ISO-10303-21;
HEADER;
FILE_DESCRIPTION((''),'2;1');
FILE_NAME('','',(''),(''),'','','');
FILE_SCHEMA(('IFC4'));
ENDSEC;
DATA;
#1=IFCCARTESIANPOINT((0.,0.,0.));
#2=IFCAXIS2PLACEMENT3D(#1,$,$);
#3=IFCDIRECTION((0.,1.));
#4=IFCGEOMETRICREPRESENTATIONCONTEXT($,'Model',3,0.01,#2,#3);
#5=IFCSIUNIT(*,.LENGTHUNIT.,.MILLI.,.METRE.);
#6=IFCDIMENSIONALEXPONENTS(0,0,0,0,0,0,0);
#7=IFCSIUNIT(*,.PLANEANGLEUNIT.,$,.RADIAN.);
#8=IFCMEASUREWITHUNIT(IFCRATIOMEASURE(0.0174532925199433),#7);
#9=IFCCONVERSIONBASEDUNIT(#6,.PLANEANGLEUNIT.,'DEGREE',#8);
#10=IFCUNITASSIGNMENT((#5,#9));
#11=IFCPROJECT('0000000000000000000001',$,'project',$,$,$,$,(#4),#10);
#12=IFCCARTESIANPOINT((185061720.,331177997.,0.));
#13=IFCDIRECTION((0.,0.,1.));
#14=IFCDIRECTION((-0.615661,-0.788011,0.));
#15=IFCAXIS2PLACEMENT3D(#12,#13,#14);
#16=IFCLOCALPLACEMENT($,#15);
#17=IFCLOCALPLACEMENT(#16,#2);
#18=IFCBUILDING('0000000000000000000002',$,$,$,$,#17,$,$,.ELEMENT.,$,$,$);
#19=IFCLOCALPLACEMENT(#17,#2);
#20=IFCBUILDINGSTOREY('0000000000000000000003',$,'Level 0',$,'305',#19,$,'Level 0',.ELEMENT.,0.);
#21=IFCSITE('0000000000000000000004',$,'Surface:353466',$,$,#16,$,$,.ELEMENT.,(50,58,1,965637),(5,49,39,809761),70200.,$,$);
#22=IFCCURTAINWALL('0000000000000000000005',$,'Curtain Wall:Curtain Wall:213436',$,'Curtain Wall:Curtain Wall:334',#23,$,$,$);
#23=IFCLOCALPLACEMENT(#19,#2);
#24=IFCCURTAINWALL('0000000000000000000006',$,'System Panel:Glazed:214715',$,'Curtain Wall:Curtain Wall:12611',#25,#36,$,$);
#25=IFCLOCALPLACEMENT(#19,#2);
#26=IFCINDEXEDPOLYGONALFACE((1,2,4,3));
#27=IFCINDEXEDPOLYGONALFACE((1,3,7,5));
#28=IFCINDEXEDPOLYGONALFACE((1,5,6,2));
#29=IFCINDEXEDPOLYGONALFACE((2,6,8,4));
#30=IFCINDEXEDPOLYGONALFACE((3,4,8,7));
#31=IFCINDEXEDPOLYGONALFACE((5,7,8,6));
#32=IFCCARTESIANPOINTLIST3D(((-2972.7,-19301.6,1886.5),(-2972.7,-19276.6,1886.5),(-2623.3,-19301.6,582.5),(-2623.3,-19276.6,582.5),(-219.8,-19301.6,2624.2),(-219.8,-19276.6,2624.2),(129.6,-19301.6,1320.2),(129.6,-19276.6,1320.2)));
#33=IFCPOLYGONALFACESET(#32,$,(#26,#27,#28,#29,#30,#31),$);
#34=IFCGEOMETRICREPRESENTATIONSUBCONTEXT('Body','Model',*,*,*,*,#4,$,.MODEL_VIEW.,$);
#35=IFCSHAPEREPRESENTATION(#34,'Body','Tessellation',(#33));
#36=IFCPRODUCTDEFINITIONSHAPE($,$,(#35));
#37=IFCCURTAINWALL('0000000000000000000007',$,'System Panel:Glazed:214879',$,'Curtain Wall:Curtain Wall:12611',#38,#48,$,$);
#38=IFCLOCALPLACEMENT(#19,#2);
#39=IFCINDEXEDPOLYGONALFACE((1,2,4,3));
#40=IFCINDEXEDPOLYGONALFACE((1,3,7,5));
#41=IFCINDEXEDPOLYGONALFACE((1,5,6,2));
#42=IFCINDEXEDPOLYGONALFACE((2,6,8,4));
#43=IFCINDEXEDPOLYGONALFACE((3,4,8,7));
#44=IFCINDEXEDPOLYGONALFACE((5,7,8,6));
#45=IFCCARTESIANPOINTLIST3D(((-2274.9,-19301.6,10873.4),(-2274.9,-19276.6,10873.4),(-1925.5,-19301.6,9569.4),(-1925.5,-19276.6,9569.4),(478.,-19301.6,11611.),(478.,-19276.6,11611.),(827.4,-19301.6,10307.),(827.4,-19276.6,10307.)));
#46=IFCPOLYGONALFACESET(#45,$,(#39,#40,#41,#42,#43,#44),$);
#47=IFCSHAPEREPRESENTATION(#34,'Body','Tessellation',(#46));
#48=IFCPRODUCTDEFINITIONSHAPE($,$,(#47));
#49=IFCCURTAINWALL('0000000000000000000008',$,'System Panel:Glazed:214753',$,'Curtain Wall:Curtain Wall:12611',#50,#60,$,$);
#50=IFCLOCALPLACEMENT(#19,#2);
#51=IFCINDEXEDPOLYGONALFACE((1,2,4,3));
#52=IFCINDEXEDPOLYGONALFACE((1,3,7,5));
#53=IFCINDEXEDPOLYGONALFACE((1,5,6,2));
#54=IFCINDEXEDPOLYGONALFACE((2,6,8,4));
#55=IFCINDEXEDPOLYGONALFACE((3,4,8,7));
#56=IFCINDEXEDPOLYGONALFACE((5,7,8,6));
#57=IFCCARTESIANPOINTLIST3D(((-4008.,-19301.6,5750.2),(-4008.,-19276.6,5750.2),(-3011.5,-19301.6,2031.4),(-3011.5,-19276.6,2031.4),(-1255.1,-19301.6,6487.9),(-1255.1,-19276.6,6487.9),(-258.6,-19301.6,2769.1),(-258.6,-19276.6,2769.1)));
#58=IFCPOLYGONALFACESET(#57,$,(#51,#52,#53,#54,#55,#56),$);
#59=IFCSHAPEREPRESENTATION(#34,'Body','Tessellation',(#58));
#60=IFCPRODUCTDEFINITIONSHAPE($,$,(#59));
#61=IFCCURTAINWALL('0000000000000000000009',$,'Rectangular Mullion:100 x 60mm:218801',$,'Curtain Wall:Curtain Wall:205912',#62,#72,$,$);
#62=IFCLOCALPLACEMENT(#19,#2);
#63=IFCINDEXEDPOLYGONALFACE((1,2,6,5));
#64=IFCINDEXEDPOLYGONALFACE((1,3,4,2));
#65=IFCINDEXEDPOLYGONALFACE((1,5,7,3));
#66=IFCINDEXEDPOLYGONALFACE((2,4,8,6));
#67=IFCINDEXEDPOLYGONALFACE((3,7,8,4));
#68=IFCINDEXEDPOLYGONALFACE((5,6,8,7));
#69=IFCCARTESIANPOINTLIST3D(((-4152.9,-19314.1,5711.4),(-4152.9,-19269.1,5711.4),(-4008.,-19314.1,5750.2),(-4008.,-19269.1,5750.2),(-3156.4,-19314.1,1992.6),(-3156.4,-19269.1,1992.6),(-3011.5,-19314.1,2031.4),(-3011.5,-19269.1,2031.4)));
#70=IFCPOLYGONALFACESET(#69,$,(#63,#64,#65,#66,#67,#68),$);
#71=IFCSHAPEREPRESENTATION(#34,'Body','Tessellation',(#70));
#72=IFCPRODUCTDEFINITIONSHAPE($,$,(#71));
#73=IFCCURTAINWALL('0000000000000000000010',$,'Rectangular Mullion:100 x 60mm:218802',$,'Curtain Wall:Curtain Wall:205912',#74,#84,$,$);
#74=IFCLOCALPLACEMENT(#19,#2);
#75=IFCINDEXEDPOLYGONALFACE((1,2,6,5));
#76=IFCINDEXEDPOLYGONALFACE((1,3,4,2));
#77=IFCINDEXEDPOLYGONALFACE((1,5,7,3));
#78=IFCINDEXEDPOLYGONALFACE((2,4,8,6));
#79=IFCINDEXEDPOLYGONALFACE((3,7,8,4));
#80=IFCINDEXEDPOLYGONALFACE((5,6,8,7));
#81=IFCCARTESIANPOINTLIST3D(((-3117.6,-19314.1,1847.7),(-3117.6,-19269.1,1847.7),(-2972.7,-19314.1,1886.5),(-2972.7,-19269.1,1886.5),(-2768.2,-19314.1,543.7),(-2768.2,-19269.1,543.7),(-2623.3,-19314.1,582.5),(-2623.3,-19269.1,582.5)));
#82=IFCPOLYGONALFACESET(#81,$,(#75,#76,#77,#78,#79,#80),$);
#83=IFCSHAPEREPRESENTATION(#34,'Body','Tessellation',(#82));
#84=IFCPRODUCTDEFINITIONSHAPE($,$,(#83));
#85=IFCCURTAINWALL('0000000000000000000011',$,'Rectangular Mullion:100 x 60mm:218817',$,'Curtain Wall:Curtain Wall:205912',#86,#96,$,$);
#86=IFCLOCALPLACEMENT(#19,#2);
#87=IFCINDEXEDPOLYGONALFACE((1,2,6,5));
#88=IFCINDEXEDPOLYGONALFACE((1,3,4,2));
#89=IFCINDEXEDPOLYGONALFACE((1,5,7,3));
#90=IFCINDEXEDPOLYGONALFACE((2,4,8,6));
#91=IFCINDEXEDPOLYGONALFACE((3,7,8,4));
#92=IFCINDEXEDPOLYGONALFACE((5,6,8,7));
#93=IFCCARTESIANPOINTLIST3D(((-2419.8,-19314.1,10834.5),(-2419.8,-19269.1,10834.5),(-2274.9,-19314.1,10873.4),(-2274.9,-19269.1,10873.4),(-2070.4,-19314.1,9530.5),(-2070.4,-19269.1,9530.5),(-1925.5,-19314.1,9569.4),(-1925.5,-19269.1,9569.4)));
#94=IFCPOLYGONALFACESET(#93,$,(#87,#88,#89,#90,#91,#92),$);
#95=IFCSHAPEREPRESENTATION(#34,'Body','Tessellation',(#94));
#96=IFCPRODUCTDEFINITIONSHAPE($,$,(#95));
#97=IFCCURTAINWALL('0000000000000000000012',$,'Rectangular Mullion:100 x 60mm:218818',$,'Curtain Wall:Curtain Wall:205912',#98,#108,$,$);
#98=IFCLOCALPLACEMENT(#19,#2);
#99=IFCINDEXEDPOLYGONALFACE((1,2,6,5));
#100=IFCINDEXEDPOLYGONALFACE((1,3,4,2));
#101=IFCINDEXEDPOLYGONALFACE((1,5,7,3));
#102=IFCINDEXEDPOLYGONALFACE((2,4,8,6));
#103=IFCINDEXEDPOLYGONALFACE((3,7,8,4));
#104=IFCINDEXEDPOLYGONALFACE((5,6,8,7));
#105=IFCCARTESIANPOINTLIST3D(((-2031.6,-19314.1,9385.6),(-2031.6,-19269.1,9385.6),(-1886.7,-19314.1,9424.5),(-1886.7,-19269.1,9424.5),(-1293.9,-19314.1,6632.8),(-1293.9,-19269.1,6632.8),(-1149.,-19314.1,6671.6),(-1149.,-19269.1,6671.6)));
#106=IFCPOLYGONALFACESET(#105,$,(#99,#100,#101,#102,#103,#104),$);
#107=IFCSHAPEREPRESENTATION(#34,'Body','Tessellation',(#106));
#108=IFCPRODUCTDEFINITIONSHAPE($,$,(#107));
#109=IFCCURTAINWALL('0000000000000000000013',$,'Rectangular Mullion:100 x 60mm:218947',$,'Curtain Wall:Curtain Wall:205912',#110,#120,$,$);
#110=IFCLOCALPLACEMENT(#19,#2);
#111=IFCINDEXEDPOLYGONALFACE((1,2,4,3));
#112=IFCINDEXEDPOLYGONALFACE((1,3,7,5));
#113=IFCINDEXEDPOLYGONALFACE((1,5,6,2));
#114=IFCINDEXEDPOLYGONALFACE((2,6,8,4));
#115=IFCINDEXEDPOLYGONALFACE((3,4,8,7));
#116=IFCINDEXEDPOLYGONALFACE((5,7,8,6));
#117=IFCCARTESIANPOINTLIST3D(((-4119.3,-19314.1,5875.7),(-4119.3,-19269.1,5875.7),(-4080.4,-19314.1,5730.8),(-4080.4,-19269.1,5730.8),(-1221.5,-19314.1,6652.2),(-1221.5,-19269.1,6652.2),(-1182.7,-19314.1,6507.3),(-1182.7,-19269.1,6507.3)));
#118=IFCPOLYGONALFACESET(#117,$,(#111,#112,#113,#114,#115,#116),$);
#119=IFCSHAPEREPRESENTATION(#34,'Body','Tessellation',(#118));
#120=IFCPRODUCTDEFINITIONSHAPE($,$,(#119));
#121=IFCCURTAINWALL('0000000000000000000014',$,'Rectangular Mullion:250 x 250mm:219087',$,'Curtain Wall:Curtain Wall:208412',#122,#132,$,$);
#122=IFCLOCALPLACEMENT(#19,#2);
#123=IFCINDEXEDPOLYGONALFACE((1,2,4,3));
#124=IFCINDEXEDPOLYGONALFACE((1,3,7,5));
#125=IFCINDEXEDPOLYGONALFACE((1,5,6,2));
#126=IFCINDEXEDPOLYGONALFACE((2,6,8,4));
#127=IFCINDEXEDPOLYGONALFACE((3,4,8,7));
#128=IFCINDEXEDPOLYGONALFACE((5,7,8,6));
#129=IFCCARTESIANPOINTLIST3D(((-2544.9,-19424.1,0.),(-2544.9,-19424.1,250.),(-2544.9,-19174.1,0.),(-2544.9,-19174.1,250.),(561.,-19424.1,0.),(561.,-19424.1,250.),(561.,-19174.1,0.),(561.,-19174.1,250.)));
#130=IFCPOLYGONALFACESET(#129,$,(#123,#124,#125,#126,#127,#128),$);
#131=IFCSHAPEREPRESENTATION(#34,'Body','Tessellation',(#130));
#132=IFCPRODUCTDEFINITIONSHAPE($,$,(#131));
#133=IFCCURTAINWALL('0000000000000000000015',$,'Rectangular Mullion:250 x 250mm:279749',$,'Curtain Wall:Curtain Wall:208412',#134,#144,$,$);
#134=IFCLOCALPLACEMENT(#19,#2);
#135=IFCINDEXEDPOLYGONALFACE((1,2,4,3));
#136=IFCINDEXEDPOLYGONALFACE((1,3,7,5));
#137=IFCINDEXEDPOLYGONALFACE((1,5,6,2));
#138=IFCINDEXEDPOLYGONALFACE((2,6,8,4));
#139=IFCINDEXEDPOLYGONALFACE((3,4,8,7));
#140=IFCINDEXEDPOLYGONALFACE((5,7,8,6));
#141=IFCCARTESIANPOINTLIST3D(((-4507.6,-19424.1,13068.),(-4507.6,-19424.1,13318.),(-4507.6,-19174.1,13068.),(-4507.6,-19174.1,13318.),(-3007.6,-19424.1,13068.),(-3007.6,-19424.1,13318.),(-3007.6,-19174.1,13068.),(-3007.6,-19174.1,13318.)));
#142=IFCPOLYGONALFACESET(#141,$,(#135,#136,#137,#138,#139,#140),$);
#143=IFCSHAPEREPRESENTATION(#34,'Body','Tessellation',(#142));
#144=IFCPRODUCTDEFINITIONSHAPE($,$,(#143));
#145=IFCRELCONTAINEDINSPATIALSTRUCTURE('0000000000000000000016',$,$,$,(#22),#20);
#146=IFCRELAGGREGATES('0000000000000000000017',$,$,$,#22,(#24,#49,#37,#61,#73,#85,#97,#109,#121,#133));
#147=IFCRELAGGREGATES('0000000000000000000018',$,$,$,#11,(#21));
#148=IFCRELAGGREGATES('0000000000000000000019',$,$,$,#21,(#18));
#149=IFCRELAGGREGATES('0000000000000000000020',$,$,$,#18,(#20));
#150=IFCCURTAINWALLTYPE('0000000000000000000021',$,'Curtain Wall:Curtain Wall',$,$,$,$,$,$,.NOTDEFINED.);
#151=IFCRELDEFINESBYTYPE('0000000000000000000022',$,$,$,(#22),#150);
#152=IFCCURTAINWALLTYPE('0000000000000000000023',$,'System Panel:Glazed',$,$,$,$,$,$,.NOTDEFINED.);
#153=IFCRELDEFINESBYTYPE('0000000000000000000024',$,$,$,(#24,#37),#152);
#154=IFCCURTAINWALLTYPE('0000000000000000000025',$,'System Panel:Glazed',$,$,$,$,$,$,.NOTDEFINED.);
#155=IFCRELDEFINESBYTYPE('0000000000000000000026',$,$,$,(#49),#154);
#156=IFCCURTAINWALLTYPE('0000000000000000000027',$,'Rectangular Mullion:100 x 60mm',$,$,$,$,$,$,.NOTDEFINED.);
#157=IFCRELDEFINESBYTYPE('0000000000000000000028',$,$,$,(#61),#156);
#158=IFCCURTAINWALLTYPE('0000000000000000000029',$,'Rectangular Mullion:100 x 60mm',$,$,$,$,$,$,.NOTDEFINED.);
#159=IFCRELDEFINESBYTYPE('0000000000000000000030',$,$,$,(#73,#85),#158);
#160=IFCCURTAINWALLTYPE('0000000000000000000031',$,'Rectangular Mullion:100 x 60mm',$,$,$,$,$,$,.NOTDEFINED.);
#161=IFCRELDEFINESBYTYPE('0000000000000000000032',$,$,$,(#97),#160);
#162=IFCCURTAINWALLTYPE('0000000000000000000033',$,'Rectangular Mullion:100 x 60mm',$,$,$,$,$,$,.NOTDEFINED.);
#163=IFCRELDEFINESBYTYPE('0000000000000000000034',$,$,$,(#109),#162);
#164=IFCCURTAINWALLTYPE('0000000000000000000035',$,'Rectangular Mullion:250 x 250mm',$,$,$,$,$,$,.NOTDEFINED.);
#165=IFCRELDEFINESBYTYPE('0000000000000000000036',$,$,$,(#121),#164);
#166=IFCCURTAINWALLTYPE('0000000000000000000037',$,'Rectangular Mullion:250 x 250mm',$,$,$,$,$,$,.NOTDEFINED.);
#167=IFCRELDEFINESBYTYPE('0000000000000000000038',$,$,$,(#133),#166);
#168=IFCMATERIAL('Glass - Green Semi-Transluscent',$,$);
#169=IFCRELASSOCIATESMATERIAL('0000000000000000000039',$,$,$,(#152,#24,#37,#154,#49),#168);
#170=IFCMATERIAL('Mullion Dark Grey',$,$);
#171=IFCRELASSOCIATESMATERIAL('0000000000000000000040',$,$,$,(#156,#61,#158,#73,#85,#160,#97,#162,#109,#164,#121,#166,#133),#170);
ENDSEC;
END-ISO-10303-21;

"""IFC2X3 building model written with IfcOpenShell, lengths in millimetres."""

from ifc_helpers import new_model, entity, si_unit, converted_unit, direction, frame, frame_2d, origin, origin_2d_with_axis, place, context, subcontext, project, spatial, rectangle, extrude, source, transform, mapped, material, type_object, type_shapes, element, aggregate, save


model = new_model("IFC2X3")

# Units and contexts
model_context = context("Model", 3, precision=0.01, world=origin(), true_north=direction((0.0, 1.0)))
body_context = subcontext(model_context, "Body", "Model", "MODEL_VIEW")
ifc_project = project(units=[si_unit("LENGTHUNIT", "METRE", prefix="MILLI"), converted_unit("PLANEANGLEUNIT", "DEGREE", entity("IfcRatioMeasure", 0.0174532925199433), si_unit("PLANEANGLEUNIT", "RADIAN"), dimensions=[0, 0, 0, 0, 0, 0, 0])], contexts=[model_context])

# Site, building, storey
site_placement = place(None, frame((185061720.0, 331177997.0, 0.0), z_axis=(0.0, 0.0, 1.0), x_axis=(-0.615661, -0.788011, 0.0)))
site = spatial("IfcSite", under=ifc_project, at=site_placement, Name="Surface:353466", CompositionType="ELEMENT", RefLatitude=(50, 58, 1, 965637), RefLongitude=(5, 49, 39, 809761), RefElevation=70200.0)
building_placement = place(site_placement, origin())
building = spatial("IfcBuilding", under=site, at=building_placement, CompositionType="ELEMENT")
storey_placement = place(building_placement, origin())
storey = spatial("IfcBuildingStorey", under=building, at=storey_placement, Name="Level 0", ObjectType="305", LongName="Level 0", CompositionType="ELEMENT", Elevation=0.0)

# Curtain walls
curtain_wall_type_1 = type_object("IfcCurtainWallType", Name="Curtain Wall:Curtain Wall", PredefinedType="NOTDEFINED")
curtain_wall_1_placement = place(storey_placement, origin())
curtain_wall_1 = element("IfcCurtainWall", 1, at=curtain_wall_1_placement, inside=storey, type_object=curtain_wall_type_1, Name="Curtain Wall:Curtain Wall:213436", ObjectType="Curtain Wall:Curtain Wall:334")
ifc_material_1 = material(Name="Glass - Green Semi-Transluscent")
curtain_wall_type_2 = type_object("IfcCurtainWallType", Name="System Panel:Glazed", PredefinedType="NOTDEFINED", material=ifc_material_1)
shared_shape_1 = source(origin(), body_context, "Body", "SweptSolid", [
    extrude(rectangle(XDim=25.0, YDim=2850.0, at=origin_2d_with_axis()), frame((0.0, 10.0, 0.0), z_axis=(0.0, 0.0, 1.0), x_axis=(0.0, 1.0, 0.0)), (0.0, 0.0, 1.0), 1350.0),
])
type_shapes(curtain_wall_type_2, [shared_shape_1])
curtain_wall_2_placement = place(storey_placement, frame((-1246.9, -19299.1, 951.4), z_axis=(-0.258819, 0.0, 0.965926), x_axis=(0.965926, 0.0, 0.258819)))
curtain_wall_2 = element("IfcCurtainWall", 2, at=curtain_wall_2_placement, type_object=curtain_wall_type_2, material=ifc_material_1, Name="System Panel:Glazed:214715", ObjectType="Curtain Wall:Curtain Wall:12611", context=body_context, shape_type="MappedRepresentation", body=[
    mapped(shared_shape_1, transform((0.0, 0.0, 0.0), scale=1.0)),
])
curtain_wall_3_placement = place(storey_placement, frame((-549.0, -19299.1, 9938.2), z_axis=(-0.258819, 0.0, 0.965926), x_axis=(0.965926, 0.0, 0.258819)))
curtain_wall_3 = element("IfcCurtainWall", 3, at=curtain_wall_3_placement, type_object=curtain_wall_type_2, material=ifc_material_1, Name="System Panel:Glazed:214879", ObjectType="Curtain Wall:Curtain Wall:12611", context=body_context, shape_type="MappedRepresentation", body=[
    mapped(shared_shape_1, transform((0.0, 0.0, 0.0), scale=1.0)),
])
curtain_wall_type_3 = type_object("IfcCurtainWallType", Name="System Panel:Glazed", PredefinedType="NOTDEFINED", material=ifc_material_1)
shared_shape_2 = source(origin(), body_context, "Body", "SweptSolid", [
    extrude(rectangle(XDim=25.0, YDim=2850.0, at=origin_2d_with_axis()), frame((0.0, 10.0, 0.0), z_axis=(0.0, 0.0, 1.0), x_axis=(0.0, 1.0, 0.0)), (0.0, 0.0, 1.0), 3850.0),
])
type_shapes(curtain_wall_type_3, [shared_shape_2])
curtain_wall_4_placement = place(storey_placement, frame((-1635.1, -19299.1, 2400.2), z_axis=(-0.258819, 0.0, 0.965926), x_axis=(0.965926, 0.0, 0.258819)))
curtain_wall_4 = element("IfcCurtainWall", 4, at=curtain_wall_4_placement, type_object=curtain_wall_type_3, material=ifc_material_1, Name="System Panel:Glazed:214753", ObjectType="Curtain Wall:Curtain Wall:12611", context=body_context, shape_type="MappedRepresentation", body=[
    mapped(shared_shape_2, transform((0.0, 0.0, 0.0), scale=1.0)),
])
ifc_material_2 = material(Name="Mullion Dark Grey")
curtain_wall_type_4 = type_object("IfcCurtainWallType", Name="Rectangular Mullion:100 x 60mm", PredefinedType="NOTDEFINED", material=ifc_material_2)
shared_shape_3 = source(origin(), body_context, "Body", "SweptSolid", [
    extrude(rectangle(XDim=150.0, YDim=45.0, at=frame_2d((0.0, 0.0), x_axis=(1.0, 0.0))), frame((0.0, -7.5, -3850.0)), (0.0, 0.0, 1.0), 3850.0),
])
type_shapes(curtain_wall_type_4, [shared_shape_3])
curtain_wall_5_placement = place(storey_placement, frame((-3084.0, -19299.1, 2012.0), z_axis=(0.258819, 0.0, -0.965926), x_axis=(0.965926, 0.0, 0.258819)))
curtain_wall_5 = element("IfcCurtainWall", 5, at=curtain_wall_5_placement, type_object=curtain_wall_type_4, material=ifc_material_2, Name="Rectangular Mullion:100 x 60mm:218801", ObjectType="Curtain Wall:Curtain Wall:205912", context=body_context, shape_type="MappedRepresentation", body=[
    mapped(shared_shape_3, transform((0.0, 0.0, 0.0), scale=1.0)),
])
curtain_wall_type_5 = type_object("IfcCurtainWallType", Name="Rectangular Mullion:100 x 60mm", PredefinedType="NOTDEFINED", material=ifc_material_2)
shared_shape_4 = source(origin(), body_context, "Body", "SweptSolid", [
    extrude(rectangle(XDim=150.0, YDim=45.0, at=frame_2d((0.0, 0.0), x_axis=(1.0, 0.0))), frame((0.0, -7.5, -1350.0)), (0.0, 0.0, 1.0), 1350.0),
])
type_shapes(curtain_wall_type_5, [shared_shape_4])
curtain_wall_6_placement = place(storey_placement, frame((-2695.8, -19299.1, 563.1), z_axis=(0.258819, 0.0, -0.965926), x_axis=(0.965926, 0.0, 0.258819)))
curtain_wall_6 = element("IfcCurtainWall", 6, at=curtain_wall_6_placement, type_object=curtain_wall_type_5, material=ifc_material_2, Name="Rectangular Mullion:100 x 60mm:218802", ObjectType="Curtain Wall:Curtain Wall:205912", context=body_context, shape_type="MappedRepresentation", body=[
    mapped(shared_shape_4, transform((0.0, 0.0, 0.0), scale=1.0)),
])
curtain_wall_7_placement = place(storey_placement, frame((-1997.9, -19299.1, 9549.9), z_axis=(0.258819, 0.0, -0.965926), x_axis=(0.965926, 0.0, 0.258819)))
curtain_wall_7 = element("IfcCurtainWall", 7, at=curtain_wall_7_placement, type_object=curtain_wall_type_5, material=ifc_material_2, Name="Rectangular Mullion:100 x 60mm:218817", ObjectType="Curtain Wall:Curtain Wall:205912", context=body_context, shape_type="MappedRepresentation", body=[
    mapped(shared_shape_4, transform((0.0, 0.0, 0.0), scale=1.0)),
])
curtain_wall_type_6 = type_object("IfcCurtainWallType", Name="Rectangular Mullion:100 x 60mm", PredefinedType="NOTDEFINED", material=ifc_material_2)
shared_shape_5 = source(origin(), body_context, "Body", "SweptSolid", [
    extrude(rectangle(XDim=150.0, YDim=45.0, at=frame_2d((0.0, 0.0), x_axis=(1.0, 0.0))), frame((0.0, -7.5, -2850.0)), (0.0, 0.0, 1.0), 2850.0),
])
type_shapes(curtain_wall_type_6, [shared_shape_5])
curtain_wall_8_placement = place(storey_placement, frame((-1221.5, -19299.1, 6652.2), z_axis=(0.258819, 0.0, -0.965926), x_axis=(0.965926, 0.0, 0.258819)))
curtain_wall_8 = element("IfcCurtainWall", 8, at=curtain_wall_8_placement, type_object=curtain_wall_type_6, material=ifc_material_2, Name="Rectangular Mullion:100 x 60mm:218818", ObjectType="Curtain Wall:Curtain Wall:205912", context=body_context, shape_type="MappedRepresentation", body=[
    mapped(shared_shape_5, transform((0.0, 0.0, 0.0), scale=1.0)),
])
curtain_wall_type_7 = type_object("IfcCurtainWallType", Name="Rectangular Mullion:100 x 60mm", PredefinedType="NOTDEFINED", material=ifc_material_2)
shared_shape_6 = source(origin(), body_context, "Body", "SweptSolid", [
    extrude(rectangle(XDim=150.0, YDim=45.0, at=frame_2d((0.0, 0.0), x_axis=(1.0, 0.0))), frame((0.0, -7.5, -3000.0)), (0.0, 0.0, 1.0), 3000.0),
])
type_shapes(curtain_wall_type_7, [shared_shape_6])
curtain_wall_9_placement = place(storey_placement, frame((-1202.1, -19299.1, 6579.7), z_axis=(0.965926, 0.0, 0.258819), x_axis=(-0.258819, 0.0, 0.965926)))
curtain_wall_9 = element("IfcCurtainWall", 9, at=curtain_wall_9_placement, type_object=curtain_wall_type_7, material=ifc_material_2, Name="Rectangular Mullion:100 x 60mm:218947", ObjectType="Curtain Wall:Curtain Wall:205912", context=body_context, shape_type="MappedRepresentation", body=[
    mapped(shared_shape_6, transform((0.0, 0.0, 0.0), scale=1.0)),
])
curtain_wall_type_8 = type_object("IfcCurtainWallType", Name="Rectangular Mullion:250 x 250mm", PredefinedType="NOTDEFINED", material=ifc_material_2)
shared_shape_7 = source(origin(), body_context, "Body", "SweptSolid", [
    extrude(rectangle(XDim=250.0, YDim=250.0, at=origin_2d_with_axis()), frame((-125.0, 0.0, -3105.8), z_axis=(0.0, 0.0, 1.0), x_axis=(-1.0, 0.0, 0.0)), (0.0, 0.0, 1.0), 3105.8),
])
type_shapes(curtain_wall_type_8, [shared_shape_7])
curtain_wall_10_placement = place(storey_placement, frame((-2544.9, -19299.1, 0.0), z_axis=(-1.0, 0.0, 0.0), x_axis=(0.0, 0.0, -1.0)))
curtain_wall_10 = element("IfcCurtainWall", 10, at=curtain_wall_10_placement, type_object=curtain_wall_type_8, material=ifc_material_2, Name="Rectangular Mullion:250 x 250mm:219087", ObjectType="Curtain Wall:Curtain Wall:208412", context=body_context, shape_type="MappedRepresentation", body=[
    mapped(shared_shape_7, transform((0.0, 0.0, 0.0), scale=1.0)),
])
curtain_wall_type_9 = type_object("IfcCurtainWallType", Name="Rectangular Mullion:250 x 250mm", PredefinedType="NOTDEFINED", material=ifc_material_2)
shared_shape_8 = source(origin(), body_context, "Body", "SweptSolid", [
    extrude(rectangle(XDim=250.0, YDim=250.0, at=origin_2d_with_axis()), frame((-125.0, 0.0, -1500.0), z_axis=(0.0, 0.0, 1.0), x_axis=(-1.0, 0.0, 0.0)), (0.0, 0.0, 1.0), 1500.0),
])
type_shapes(curtain_wall_type_9, [shared_shape_8])
curtain_wall_11_placement = place(storey_placement, frame((-3007.6, -19299.1, 13318.0), z_axis=(1.0, 0.0, 0.0), x_axis=(0.0, 0.0, 1.0)))
curtain_wall_11 = element("IfcCurtainWall", 11, at=curtain_wall_11_placement, type_object=curtain_wall_type_9, material=ifc_material_2, Name="Rectangular Mullion:250 x 250mm:279749", ObjectType="Curtain Wall:Curtain Wall:208412", context=body_context, shape_type="MappedRepresentation", body=[
    mapped(shared_shape_8, transform((0.0, 0.0, 0.0), scale=1.0)),
])
aggregate(curtain_wall_1, [curtain_wall_2, curtain_wall_4, curtain_wall_3, curtain_wall_5, curtain_wall_6, curtain_wall_7, curtain_wall_8, curtain_wall_9, curtain_wall_10, curtain_wall_11])

save(model, "model.ifc")
